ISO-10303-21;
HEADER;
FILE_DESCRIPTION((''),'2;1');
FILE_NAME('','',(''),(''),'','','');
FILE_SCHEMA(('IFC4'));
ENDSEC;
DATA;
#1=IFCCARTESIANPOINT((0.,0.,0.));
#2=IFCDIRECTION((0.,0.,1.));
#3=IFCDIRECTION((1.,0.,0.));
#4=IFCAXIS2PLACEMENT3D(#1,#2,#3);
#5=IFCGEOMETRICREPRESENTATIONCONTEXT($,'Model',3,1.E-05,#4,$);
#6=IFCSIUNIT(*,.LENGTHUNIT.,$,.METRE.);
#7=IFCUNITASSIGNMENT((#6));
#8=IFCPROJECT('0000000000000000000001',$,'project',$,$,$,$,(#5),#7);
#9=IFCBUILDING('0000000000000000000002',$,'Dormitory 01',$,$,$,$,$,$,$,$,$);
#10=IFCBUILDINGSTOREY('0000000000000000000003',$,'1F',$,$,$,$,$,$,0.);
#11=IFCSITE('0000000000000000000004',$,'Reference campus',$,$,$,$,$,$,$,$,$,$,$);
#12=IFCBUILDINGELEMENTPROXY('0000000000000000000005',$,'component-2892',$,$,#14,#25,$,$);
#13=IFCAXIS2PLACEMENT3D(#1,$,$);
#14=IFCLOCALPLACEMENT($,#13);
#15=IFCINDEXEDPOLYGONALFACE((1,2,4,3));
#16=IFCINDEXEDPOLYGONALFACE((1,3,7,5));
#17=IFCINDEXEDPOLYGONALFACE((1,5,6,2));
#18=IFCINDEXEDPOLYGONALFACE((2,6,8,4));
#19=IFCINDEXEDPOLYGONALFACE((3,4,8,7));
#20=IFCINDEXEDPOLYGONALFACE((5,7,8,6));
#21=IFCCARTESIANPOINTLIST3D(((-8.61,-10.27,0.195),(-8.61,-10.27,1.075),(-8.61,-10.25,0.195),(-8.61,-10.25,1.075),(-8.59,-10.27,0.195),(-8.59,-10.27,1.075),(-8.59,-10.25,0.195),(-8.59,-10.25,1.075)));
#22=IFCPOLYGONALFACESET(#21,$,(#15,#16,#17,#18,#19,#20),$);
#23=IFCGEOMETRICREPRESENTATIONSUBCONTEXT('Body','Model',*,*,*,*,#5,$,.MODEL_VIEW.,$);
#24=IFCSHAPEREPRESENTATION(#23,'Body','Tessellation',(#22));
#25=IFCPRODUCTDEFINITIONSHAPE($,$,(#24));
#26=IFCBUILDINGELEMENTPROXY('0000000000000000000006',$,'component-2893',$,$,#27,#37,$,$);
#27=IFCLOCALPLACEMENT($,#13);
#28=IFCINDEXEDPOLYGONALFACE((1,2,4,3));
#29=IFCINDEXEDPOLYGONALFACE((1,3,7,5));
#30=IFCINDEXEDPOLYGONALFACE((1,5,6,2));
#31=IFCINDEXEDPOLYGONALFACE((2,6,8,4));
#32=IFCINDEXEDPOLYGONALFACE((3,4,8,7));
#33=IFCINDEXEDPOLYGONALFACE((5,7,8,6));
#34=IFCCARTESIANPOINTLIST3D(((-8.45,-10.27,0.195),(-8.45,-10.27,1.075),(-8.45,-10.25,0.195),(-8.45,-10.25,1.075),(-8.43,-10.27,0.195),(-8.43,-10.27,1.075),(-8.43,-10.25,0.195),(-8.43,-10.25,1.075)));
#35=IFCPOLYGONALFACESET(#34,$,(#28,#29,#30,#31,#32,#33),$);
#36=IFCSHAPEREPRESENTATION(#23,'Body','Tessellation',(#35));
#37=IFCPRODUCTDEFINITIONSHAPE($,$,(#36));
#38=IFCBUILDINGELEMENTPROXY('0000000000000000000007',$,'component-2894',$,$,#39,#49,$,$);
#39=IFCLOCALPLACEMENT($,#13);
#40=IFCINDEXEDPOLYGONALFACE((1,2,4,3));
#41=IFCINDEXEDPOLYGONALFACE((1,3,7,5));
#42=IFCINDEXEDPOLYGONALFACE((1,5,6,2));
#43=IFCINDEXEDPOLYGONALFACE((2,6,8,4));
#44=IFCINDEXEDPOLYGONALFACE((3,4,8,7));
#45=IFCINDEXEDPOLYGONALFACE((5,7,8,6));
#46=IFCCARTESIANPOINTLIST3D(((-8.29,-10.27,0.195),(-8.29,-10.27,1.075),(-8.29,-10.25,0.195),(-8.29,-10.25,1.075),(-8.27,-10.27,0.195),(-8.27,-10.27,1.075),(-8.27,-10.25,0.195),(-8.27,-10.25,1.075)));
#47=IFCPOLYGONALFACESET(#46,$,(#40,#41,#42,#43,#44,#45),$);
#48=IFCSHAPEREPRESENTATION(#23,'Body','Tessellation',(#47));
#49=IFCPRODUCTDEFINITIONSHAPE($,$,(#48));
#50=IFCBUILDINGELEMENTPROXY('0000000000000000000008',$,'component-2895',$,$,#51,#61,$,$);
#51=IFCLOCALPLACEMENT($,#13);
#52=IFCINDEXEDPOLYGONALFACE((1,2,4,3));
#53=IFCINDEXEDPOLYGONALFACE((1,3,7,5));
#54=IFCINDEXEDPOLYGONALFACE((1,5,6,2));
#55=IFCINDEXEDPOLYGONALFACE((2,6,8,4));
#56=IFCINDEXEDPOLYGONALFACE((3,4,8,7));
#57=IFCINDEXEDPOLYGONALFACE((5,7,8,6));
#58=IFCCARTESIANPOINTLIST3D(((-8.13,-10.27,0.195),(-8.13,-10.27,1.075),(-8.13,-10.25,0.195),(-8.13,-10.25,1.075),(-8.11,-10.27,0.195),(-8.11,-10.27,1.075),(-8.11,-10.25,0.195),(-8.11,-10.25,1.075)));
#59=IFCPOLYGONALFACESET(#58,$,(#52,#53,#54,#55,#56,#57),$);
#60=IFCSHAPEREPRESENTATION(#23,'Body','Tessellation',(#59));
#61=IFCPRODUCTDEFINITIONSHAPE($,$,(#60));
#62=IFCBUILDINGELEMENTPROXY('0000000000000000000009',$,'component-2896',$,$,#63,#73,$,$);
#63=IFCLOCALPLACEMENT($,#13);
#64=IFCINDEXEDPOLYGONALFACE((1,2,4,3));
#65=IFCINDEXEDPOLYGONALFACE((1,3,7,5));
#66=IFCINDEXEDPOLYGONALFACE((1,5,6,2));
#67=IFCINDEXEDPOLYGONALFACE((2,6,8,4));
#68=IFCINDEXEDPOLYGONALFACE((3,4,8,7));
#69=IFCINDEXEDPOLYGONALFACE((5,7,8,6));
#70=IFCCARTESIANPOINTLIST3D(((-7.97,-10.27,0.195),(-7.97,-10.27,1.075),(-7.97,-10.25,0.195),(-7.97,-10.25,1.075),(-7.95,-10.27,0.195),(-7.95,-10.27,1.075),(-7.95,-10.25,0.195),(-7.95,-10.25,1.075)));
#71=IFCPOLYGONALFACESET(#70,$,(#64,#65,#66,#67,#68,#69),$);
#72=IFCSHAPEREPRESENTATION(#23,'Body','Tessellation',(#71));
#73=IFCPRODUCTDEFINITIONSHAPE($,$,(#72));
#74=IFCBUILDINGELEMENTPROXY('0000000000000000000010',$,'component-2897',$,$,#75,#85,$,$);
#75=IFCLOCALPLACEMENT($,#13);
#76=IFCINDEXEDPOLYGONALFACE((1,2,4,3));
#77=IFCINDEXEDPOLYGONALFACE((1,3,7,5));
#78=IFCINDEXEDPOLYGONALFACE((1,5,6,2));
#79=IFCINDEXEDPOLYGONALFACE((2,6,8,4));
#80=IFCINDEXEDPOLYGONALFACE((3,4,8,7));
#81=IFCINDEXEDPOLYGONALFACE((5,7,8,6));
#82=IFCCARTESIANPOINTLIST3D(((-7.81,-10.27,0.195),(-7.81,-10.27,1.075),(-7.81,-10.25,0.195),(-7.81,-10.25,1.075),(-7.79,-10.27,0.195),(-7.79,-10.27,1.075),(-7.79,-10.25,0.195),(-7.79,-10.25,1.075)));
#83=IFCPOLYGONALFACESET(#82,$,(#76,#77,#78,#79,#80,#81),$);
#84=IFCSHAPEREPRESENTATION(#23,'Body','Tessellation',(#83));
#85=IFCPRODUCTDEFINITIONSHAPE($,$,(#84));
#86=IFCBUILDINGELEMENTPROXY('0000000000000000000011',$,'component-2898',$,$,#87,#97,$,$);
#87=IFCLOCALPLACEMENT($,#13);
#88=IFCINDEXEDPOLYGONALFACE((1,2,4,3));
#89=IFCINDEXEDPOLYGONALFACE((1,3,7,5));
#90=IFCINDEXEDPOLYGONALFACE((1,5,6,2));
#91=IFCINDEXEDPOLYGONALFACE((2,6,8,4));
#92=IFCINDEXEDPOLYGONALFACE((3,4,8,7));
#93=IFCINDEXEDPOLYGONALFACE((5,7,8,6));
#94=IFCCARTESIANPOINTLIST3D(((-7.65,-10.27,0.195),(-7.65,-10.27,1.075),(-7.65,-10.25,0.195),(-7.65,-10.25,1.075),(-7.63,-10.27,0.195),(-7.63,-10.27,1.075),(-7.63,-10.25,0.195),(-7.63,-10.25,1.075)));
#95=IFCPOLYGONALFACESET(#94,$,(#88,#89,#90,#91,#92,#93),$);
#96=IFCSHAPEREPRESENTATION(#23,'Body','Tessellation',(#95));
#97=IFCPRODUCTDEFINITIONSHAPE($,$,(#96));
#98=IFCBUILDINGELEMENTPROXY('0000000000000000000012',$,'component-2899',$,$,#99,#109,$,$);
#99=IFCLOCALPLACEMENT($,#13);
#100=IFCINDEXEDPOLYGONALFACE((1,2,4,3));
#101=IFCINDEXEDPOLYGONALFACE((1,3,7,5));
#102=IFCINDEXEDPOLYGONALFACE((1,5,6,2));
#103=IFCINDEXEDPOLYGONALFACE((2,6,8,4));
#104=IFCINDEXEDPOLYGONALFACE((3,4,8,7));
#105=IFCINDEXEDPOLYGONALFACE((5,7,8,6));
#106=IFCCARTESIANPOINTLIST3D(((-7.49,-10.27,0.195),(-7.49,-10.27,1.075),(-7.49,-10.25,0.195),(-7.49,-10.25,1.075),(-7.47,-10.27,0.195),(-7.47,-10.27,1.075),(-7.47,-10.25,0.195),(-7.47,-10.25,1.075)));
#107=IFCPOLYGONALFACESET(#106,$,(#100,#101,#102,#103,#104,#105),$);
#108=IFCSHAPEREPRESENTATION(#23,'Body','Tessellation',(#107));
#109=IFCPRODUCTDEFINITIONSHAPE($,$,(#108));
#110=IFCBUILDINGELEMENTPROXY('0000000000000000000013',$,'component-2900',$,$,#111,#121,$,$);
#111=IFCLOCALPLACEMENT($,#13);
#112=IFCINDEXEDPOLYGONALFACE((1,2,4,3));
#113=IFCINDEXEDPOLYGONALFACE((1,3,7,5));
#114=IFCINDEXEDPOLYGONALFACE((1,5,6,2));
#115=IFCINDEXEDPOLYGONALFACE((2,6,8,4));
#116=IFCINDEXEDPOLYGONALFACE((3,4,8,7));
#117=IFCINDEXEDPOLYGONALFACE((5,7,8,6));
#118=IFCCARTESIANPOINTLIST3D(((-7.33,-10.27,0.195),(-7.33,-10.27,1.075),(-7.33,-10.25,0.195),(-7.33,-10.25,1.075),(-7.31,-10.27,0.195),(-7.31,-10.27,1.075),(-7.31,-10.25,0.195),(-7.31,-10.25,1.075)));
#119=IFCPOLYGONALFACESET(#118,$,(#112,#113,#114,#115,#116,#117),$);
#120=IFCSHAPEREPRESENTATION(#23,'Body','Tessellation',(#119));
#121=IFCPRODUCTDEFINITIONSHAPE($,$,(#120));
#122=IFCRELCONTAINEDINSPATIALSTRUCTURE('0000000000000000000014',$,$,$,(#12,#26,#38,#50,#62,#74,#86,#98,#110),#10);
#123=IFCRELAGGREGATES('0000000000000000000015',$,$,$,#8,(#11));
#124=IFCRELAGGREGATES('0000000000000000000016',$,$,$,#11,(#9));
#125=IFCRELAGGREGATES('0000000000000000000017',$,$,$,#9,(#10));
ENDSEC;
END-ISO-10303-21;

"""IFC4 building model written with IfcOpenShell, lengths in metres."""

from ifc_helpers import new_model, si_unit, frame, origin, origin_with_axes, origin_2d, place, context, subcontext, project, spatial, rectangle, extrude, element, save


model = new_model("IFC4")

# Units and contexts
model_context = context("Model", 3, precision=1e-05, world=origin_with_axes())
body_context = subcontext(model_context, "Body", "Model", "MODEL_VIEW")
ifc_project = project(units=[si_unit("LENGTHUNIT", "METRE")], contexts=[model_context])

# Site, building, storey
site = spatial("IfcSite", under=ifc_project, Name="Reference campus")
building = spatial("IfcBuilding", under=site, Name="Dormitory 01")
storey = spatial("IfcBuildingStorey", under=building, Name="1F", Elevation=0.0)

# Building element proxies
for number, where, z_axis, x_axis, name in (
    (1, (-8.6, -10.26, 0.195), (0.0, 0.0, 1.0), (1.0, 0.0, 0.0), "component-2892"),
    (2, (-8.44, -10.26, 0.195), (0.0, 0.0, 1.0), (1.0, 0.0, 0.0), "component-2893"),
    (3, (-8.28, -10.26, 0.195), (0.0, 0.0, 1.0), (1.0, 0.0, 0.0), "component-2894"),
    (4, (-8.12, -10.26, 0.195), (0.0, 0.0, 1.0), (1.0, 0.0, 0.0), "component-2895"),
    (5, (-7.96, -10.26, 0.195), (0.0, 0.0, 1.0), (1.0, 0.0, 0.0), "component-2896"),
    (6, (-7.8, -10.26, 0.195), (0.0, 0.0, 1.0), (1.0, 0.0, 0.0), "component-2897"),
    (7, (-7.64, -10.26, 0.195), (0.0, 0.0, 1.0), (1.0, 0.0, 0.0), "component-2898"),
    (8, (-7.48, -10.26, 0.195), (0.0, 0.0, 1.0), (1.0, 0.0, 0.0), "component-2899"),
    (9, (-7.32, -10.26, 0.195), (0.0, 0.0, 1.0), (1.0, 0.0, 0.0), "component-2900"),
):
    element("IfcBuildingElementProxy", number, at=place(None, frame(where, z_axis=z_axis, x_axis=x_axis)), inside=storey, Name=name, context=body_context, shape_type="SweptSolid", body=[
        extrude(rectangle(XDim=0.02, YDim=0.02, at=origin_2d()), origin(), (0.0, 0.0, 1.0), 0.88),
    ])

save(model, "model.ifc")
